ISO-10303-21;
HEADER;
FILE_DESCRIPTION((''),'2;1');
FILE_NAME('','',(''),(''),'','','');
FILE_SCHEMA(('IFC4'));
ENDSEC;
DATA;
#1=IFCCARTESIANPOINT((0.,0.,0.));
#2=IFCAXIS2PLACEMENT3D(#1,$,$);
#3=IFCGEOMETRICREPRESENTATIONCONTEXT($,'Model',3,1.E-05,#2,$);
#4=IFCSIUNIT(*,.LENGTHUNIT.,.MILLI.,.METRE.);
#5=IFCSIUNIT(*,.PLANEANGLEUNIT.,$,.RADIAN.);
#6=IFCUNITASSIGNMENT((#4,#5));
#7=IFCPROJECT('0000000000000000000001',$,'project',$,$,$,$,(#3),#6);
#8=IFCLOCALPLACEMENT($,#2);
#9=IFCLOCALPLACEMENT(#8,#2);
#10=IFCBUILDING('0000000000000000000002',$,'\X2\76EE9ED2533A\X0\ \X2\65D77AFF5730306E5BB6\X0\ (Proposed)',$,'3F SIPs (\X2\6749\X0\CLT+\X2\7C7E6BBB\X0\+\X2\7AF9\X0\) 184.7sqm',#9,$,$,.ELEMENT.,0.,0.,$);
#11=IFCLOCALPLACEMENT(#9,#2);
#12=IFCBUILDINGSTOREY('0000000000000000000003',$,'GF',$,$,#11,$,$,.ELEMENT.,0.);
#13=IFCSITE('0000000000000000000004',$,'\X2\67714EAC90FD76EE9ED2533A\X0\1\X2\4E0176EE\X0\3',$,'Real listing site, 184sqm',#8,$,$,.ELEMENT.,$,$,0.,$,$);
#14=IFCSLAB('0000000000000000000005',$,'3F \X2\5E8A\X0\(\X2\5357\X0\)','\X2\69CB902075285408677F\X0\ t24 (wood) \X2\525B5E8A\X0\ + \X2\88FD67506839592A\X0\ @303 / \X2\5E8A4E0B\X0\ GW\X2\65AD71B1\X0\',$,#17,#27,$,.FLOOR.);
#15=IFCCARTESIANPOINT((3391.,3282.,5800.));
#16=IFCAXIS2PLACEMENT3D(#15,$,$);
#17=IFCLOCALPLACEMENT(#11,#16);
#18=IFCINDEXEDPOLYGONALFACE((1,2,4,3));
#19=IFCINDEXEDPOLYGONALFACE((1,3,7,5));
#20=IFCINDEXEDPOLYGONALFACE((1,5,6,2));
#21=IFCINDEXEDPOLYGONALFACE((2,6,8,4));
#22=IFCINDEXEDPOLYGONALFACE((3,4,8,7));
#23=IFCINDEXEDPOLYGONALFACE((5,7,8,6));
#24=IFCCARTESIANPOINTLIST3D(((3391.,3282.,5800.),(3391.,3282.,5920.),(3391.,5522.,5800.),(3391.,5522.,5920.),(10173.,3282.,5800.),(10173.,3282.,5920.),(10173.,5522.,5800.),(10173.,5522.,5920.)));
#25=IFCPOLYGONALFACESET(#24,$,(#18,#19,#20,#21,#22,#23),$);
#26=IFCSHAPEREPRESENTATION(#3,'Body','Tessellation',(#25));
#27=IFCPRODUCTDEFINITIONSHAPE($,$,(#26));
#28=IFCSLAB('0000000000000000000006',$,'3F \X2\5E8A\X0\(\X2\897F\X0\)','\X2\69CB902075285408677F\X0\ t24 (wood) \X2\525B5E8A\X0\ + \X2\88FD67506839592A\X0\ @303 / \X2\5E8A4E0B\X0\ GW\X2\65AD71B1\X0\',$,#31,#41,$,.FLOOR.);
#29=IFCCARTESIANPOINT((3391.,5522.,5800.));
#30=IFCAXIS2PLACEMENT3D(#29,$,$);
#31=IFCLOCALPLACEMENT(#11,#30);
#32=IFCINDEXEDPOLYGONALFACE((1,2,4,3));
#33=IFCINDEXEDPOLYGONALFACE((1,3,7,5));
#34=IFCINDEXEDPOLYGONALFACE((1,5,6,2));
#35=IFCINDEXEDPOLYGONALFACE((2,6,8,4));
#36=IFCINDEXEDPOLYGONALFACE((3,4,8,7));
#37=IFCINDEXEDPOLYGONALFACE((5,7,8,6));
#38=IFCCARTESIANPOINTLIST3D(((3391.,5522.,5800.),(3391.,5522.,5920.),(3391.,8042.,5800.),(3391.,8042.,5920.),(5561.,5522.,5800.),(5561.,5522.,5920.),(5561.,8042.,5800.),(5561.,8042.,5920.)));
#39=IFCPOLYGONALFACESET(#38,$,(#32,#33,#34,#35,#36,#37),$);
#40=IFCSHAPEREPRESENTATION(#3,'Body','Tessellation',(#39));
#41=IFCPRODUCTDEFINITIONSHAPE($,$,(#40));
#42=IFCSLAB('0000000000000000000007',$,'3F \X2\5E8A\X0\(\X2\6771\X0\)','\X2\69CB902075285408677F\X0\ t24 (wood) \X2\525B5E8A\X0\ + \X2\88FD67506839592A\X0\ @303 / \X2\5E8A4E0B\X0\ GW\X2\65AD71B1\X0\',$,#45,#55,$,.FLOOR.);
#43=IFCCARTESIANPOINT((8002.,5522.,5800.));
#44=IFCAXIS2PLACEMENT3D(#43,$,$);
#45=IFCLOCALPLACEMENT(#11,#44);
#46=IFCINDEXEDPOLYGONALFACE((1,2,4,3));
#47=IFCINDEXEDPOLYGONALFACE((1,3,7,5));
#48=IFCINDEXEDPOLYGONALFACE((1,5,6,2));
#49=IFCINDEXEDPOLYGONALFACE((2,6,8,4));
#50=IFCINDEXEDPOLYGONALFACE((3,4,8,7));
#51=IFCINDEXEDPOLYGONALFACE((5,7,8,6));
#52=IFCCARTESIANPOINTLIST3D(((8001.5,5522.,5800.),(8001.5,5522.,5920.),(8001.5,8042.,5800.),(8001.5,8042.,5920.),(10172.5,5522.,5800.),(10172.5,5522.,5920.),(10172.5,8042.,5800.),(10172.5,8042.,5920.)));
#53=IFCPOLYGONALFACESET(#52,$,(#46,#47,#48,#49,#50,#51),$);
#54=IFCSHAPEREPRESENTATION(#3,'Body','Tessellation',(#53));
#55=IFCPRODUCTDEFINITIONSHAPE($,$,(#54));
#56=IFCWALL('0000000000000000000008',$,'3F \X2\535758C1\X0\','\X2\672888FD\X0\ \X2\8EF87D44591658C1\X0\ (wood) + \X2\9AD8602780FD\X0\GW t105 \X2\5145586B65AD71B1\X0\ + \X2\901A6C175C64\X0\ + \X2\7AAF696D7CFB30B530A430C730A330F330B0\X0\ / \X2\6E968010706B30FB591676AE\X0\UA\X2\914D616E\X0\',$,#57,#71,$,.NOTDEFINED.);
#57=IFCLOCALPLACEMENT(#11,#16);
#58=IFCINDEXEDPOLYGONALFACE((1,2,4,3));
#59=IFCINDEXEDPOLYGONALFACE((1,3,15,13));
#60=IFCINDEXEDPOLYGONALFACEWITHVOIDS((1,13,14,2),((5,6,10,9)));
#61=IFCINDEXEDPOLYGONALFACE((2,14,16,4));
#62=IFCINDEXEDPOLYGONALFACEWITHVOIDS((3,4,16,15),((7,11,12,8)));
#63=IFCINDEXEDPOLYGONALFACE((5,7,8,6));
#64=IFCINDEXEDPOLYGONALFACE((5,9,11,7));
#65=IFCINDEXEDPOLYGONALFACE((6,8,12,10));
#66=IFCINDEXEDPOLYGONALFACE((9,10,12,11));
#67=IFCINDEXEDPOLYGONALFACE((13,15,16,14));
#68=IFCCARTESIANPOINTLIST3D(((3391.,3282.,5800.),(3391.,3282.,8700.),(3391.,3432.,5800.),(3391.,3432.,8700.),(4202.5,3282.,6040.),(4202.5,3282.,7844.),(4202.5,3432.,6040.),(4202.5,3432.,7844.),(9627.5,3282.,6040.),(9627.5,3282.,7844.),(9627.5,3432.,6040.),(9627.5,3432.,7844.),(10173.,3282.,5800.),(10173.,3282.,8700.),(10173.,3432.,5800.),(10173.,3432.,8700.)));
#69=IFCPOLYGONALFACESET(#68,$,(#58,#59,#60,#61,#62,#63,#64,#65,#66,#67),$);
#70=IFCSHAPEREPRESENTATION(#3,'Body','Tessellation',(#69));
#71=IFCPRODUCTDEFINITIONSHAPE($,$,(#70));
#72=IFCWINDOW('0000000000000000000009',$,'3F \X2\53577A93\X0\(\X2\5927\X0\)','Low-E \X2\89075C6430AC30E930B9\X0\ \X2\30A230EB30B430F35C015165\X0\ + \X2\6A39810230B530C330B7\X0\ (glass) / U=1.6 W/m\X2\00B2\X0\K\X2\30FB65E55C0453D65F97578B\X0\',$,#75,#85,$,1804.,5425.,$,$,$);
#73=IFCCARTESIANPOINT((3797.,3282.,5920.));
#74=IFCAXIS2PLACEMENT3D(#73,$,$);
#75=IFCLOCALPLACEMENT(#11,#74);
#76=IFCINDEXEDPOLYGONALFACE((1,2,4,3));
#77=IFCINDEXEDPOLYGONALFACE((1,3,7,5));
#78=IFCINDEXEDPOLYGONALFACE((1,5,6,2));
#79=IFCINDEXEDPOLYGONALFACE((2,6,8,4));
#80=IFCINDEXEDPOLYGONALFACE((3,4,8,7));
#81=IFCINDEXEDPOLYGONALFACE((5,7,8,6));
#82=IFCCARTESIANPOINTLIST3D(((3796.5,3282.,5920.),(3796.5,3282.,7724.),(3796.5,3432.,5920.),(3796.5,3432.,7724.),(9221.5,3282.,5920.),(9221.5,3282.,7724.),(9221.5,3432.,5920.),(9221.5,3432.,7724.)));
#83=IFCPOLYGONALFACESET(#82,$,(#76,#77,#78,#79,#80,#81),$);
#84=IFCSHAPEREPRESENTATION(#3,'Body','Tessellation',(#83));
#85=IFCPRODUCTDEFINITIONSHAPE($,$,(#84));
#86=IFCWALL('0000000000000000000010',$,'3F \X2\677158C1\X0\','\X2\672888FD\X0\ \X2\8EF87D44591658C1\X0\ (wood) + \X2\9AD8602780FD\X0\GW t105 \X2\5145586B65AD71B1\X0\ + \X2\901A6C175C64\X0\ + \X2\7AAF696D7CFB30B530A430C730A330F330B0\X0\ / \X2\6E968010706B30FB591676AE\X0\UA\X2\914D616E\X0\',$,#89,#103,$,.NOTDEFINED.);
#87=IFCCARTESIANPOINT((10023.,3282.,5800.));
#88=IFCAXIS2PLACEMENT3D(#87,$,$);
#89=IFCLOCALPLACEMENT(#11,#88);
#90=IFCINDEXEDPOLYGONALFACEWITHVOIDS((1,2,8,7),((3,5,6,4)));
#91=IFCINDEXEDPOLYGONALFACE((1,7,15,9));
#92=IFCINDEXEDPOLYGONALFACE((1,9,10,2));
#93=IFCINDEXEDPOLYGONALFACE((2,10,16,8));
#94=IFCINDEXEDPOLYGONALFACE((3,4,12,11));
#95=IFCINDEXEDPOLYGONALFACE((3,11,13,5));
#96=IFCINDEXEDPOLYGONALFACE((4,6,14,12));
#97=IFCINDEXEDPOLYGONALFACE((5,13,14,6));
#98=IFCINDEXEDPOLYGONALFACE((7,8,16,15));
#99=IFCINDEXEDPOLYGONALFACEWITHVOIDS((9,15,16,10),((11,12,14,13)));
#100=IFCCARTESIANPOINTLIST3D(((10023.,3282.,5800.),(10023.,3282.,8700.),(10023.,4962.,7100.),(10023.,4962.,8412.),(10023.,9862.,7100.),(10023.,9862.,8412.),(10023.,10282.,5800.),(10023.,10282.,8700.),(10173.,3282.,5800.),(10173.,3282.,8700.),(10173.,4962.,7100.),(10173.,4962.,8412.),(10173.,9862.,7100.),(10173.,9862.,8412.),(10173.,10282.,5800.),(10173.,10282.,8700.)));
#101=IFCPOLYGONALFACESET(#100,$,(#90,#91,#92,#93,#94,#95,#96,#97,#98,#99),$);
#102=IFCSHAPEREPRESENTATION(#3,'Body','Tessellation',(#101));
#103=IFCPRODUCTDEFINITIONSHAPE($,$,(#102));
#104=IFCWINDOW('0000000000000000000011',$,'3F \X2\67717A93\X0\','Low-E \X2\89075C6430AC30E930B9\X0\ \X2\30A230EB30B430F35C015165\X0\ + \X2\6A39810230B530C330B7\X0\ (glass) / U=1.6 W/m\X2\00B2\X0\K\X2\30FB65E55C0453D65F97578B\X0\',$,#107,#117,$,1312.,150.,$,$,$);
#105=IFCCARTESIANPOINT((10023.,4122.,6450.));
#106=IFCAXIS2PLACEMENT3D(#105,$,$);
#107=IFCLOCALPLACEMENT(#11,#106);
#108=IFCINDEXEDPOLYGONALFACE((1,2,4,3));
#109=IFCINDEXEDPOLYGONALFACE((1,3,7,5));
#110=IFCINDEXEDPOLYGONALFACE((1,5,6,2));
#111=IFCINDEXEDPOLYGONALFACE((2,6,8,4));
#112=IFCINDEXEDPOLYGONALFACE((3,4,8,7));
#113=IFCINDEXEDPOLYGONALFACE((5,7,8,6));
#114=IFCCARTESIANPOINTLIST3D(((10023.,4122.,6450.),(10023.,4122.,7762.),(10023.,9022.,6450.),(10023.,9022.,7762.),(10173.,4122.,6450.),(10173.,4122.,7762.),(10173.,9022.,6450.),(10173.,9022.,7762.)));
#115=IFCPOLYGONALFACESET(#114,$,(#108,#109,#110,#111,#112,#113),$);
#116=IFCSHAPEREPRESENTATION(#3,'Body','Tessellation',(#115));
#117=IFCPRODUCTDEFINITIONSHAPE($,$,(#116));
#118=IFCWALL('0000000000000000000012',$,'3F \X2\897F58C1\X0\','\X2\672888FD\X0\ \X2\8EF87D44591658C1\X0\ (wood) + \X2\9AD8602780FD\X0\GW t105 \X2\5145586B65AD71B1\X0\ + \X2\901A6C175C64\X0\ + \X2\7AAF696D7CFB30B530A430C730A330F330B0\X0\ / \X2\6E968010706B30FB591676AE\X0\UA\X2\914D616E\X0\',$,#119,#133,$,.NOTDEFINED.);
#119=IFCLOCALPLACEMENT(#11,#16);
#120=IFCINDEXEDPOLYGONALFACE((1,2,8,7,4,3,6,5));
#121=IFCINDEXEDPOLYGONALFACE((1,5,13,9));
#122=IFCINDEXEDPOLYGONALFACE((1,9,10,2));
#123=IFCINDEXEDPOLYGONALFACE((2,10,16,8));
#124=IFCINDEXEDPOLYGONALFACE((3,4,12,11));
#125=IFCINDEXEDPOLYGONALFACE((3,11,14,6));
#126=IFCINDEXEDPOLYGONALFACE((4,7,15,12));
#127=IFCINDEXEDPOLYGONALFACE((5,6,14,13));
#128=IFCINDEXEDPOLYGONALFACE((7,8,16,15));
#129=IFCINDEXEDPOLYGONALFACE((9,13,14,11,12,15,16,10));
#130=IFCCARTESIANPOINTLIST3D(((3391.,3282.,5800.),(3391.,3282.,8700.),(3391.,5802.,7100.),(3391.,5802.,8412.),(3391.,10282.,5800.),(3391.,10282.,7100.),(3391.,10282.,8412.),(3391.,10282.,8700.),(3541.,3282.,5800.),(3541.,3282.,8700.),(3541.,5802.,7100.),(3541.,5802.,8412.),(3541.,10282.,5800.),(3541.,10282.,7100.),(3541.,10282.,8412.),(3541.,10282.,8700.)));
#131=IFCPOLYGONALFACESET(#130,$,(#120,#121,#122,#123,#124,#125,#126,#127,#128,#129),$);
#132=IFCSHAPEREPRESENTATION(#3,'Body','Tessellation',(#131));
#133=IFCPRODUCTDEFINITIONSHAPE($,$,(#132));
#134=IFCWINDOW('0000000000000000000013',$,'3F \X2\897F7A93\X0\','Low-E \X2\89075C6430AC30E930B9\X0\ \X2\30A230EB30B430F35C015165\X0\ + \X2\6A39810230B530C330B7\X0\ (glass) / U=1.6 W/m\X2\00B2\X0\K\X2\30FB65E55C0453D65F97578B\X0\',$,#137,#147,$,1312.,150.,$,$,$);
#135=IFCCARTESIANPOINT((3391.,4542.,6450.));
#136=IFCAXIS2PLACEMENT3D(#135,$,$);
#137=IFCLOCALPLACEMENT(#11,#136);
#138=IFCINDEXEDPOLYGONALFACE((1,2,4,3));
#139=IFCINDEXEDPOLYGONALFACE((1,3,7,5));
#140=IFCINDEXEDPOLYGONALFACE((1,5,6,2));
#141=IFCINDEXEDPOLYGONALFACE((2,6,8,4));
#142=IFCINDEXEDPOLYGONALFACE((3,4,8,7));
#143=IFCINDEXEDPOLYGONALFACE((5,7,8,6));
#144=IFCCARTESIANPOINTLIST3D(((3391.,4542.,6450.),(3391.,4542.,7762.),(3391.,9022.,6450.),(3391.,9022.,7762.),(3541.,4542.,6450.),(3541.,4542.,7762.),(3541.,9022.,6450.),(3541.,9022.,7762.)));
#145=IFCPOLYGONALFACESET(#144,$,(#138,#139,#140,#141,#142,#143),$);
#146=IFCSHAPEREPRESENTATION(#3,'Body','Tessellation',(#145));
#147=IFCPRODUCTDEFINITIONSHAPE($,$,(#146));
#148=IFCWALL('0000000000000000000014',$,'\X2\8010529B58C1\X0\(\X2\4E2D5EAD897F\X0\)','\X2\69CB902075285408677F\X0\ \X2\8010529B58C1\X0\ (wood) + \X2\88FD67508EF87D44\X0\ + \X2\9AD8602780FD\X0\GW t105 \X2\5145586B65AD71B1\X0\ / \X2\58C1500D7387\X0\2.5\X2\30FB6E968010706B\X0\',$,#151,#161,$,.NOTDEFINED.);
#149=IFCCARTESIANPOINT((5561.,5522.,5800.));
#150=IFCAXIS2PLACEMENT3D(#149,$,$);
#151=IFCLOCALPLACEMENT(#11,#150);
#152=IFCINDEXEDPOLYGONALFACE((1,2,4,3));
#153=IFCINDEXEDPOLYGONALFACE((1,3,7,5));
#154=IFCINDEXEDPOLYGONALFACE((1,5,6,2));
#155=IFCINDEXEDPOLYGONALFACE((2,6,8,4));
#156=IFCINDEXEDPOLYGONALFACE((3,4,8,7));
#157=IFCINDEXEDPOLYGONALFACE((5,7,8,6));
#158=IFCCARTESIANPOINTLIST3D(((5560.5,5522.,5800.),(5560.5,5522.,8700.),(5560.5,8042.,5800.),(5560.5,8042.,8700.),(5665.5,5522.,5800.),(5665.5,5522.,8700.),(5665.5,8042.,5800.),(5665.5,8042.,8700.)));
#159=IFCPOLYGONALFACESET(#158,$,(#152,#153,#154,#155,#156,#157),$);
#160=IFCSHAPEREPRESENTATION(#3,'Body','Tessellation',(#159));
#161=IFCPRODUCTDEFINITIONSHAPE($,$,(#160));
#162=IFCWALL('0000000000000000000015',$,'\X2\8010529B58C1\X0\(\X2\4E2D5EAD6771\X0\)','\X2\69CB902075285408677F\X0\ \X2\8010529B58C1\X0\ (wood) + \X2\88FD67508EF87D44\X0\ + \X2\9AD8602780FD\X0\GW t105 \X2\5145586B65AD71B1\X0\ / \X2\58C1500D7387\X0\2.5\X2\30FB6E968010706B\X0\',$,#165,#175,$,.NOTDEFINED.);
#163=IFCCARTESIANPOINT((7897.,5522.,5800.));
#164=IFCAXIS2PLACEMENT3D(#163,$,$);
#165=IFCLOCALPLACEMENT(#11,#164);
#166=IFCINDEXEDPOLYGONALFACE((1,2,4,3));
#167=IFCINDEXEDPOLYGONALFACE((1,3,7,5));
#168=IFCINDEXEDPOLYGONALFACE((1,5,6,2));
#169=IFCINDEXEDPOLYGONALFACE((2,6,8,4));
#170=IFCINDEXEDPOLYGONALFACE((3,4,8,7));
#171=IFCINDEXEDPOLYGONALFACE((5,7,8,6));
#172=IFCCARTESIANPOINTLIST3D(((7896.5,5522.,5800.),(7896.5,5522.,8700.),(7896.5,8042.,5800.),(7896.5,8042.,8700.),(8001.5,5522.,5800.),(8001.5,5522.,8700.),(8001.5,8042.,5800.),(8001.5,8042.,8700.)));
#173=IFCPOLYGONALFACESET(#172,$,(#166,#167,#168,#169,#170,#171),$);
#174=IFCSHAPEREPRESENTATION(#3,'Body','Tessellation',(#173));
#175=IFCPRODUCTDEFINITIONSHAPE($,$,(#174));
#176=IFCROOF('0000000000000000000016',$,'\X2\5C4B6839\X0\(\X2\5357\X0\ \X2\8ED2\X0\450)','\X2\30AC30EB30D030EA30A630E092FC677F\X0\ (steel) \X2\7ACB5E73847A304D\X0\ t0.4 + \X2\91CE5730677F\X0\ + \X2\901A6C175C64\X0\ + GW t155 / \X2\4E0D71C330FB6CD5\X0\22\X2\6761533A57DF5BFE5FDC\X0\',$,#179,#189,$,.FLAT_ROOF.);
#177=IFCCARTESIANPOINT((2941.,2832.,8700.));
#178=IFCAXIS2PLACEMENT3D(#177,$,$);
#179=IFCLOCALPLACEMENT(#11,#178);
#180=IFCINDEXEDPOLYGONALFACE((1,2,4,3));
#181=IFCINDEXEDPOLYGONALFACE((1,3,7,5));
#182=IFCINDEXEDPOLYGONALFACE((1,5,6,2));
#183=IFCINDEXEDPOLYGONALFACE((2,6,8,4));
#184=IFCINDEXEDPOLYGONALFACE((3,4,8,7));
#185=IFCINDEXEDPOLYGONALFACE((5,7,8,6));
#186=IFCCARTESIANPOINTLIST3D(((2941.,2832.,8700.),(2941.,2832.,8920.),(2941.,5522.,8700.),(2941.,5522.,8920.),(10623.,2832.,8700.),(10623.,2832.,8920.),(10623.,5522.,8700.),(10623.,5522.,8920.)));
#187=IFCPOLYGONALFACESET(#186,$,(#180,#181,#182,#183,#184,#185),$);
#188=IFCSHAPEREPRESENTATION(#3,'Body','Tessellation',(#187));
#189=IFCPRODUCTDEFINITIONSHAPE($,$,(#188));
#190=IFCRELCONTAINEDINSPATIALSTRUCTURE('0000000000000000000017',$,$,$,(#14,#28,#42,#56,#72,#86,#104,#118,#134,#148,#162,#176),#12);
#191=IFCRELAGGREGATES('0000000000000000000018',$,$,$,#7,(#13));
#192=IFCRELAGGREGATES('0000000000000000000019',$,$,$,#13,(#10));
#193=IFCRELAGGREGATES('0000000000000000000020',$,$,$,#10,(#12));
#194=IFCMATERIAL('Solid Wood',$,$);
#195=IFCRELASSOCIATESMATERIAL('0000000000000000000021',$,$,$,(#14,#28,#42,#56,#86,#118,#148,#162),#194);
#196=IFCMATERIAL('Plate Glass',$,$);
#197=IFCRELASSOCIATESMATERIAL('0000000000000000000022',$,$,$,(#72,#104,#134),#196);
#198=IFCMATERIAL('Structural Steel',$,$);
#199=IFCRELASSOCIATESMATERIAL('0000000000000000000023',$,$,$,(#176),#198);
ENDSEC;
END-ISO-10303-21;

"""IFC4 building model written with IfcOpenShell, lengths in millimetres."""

from ifc_helpers import new_model, si_unit, frame, frame_2d, origin, place, context, project, spatial, rectangle, extrude, material, element, fill, save


model = new_model("IFC4")

# Units and contexts
model_context = context("Model", 3, precision=1e-05, world=origin())
ifc_project = project(units=[si_unit("LENGTHUNIT", "METRE", prefix="MILLI"), si_unit("PLANEANGLEUNIT", "RADIAN")], contexts=[model_context])

# Site, building, storey
site_placement = place(None, origin())
site = spatial("IfcSite", under=ifc_project, at=site_placement, Name="東京都目黒区1丁目3", ObjectType="Real listing site, 184sqm", CompositionType="ELEMENT", RefElevation=0.0)
building_placement = place(site_placement, origin())
building = spatial("IfcBuilding", under=site, at=building_placement, Name="目黒区 旗竿地の家 (Proposed)", ObjectType="3F SIPs (杉CLT+籾殻+竹) 184.7sqm", CompositionType="ELEMENT", ElevationOfRefHeight=0.0, ElevationOfTerrain=0.0)
storey_placement = place(building_placement, origin())
storey = spatial("IfcBuildingStorey", under=building, at=storey_placement, Name="GF", CompositionType="ELEMENT", Elevation=0.0)

# Slabs
ifc_material_1 = material(Name="Solid Wood")
slab_1_placement = place(storey_placement, frame((3391.0, 3282.0, 5800.0)))
element("IfcSlab", 1, at=slab_1_placement, inside=storey, material=ifc_material_1, Name="3F 床(南)", Description="構造用合板 t24 (wood) 剛床 + 製材根太 @303 / 床下 GW断熱", PredefinedType="FLOOR", context=model_context, shape_type="SweptSolid", body=[
    extrude(rectangle(XDim=6782.0, YDim=2240.0, at=frame_2d((3391.0, 1120.0))), frame((3391.0, 3282.0, 5800.0)), (0.0, 0.0, 1.0), 120.0),
])
slab_2_placement = place(storey_placement, frame((3391.0, 5522.0, 5800.0)))
element("IfcSlab", 2, at=slab_2_placement, inside=storey, material=ifc_material_1, Name="3F 床(西)", Description="構造用合板 t24 (wood) 剛床 + 製材根太 @303 / 床下 GW断熱", PredefinedType="FLOOR", context=model_context, shape_type="SweptSolid", body=[
    extrude(rectangle(XDim=2170.0, YDim=2520.0, at=frame_2d((1085.0, 1260.0))), frame((3391.0, 5522.0, 5800.0)), (0.0, 0.0, 1.0), 120.0),
])
slab_3_placement = place(storey_placement, frame((8002.0, 5522.0, 5800.0)))
element("IfcSlab", 3, at=slab_3_placement, inside=storey, material=ifc_material_1, Name="3F 床(東)", Description="構造用合板 t24 (wood) 剛床 + 製材根太 @303 / 床下 GW断熱", PredefinedType="FLOOR", context=model_context, shape_type="SweptSolid", body=[
    extrude(rectangle(XDim=2171.0, YDim=2520.0, at=frame_2d((1085.0, 1260.0))), frame((8002.0, 5522.0, 5800.0)), (0.0, 0.0, 1.0), 120.0),
])

# Walls, openings, windows
wall_1_placement = place(storey_placement, frame((3391.0, 3282.0, 5800.0)))
wall_1 = element("IfcWall", 4, at=wall_1_placement, inside=storey, material=ifc_material_1, Name="3F 南壁", Description="木製 軸組外壁 (wood) + 高性能GW t105 充填断熱 + 通気層 + 窯業系サイディング / 準耐火・外皮UA配慮", PredefinedType="NOTDEFINED", context=model_context, shape_type="SweptSolid", body=[
    extrude(rectangle(XDim=6782.0, YDim=150.0, at=frame_2d((3391.0, 75.0))), frame((3391.0, 3282.0, 5800.0)), (0.0, 0.0, 1.0), 2900.0),
])
opening_1_placement = place(storey_placement, frame((3797.0, 3282.0, 5920.0)))
opening_1 = element("IfcOpeningElement", 5, at=opening_1_placement, cuts=wall_1, PredefinedType="NOTDEFINED", context=model_context, shape_type="SweptSolid", body=[
    extrude(rectangle(XDim=5425.0, YDim=150.0, at=frame_2d((2712.0, 75.0))), frame((3797.0, 3282.0, 5920.0)), (0.0, 0.0, 1.0), 1804.0),
])
ifc_material_2 = material(Name="Plate Glass")
window_1_placement = place(storey_placement, frame((3797.0, 3282.0, 5920.0)))
window_1 = element("IfcWindow", 6, at=window_1_placement, inside=storey, material=ifc_material_2, Name="3F 南窓(大)", Description="Low-E 複層ガラス アルゴン封入 + 樹脂サッシ (glass) / U=1.6 W/m²K・日射取得型", OverallHeight=1804.0, OverallWidth=5425.0, context=model_context, shape_type="SweptSolid", body=[
    extrude(rectangle(XDim=5425.0, YDim=150.0, at=frame_2d((2712.0, 75.0))), frame((3797.0, 3282.0, 5920.0)), (0.0, 0.0, 1.0), 1804.0),
])
fill(opening_1, window_1)
wall_2_placement = place(storey_placement, frame((10023.0, 3282.0, 5800.0)))
wall_2 = element("IfcWall", 7, at=wall_2_placement, inside=storey, material=ifc_material_1, Name="3F 東壁", Description="木製 軸組外壁 (wood) + 高性能GW t105 充填断熱 + 通気層 + 窯業系サイディング / 準耐火・外皮UA配慮", PredefinedType="NOTDEFINED", context=model_context, shape_type="SweptSolid", body=[
    extrude(rectangle(XDim=150.0, YDim=7000.0, at=frame_2d((75.0, 3500.0))), frame((10023.0, 3282.0, 5800.0)), (0.0, 0.0, 1.0), 2900.0),
])
opening_2_placement = place(storey_placement, frame((10023.0, 4122.0, 6450.0)))
opening_2 = element("IfcOpeningElement", 8, at=opening_2_placement, cuts=wall_2, PredefinedType="NOTDEFINED", context=model_context, shape_type="SweptSolid", body=[
    extrude(rectangle(XDim=150.0, YDim=4900.0, at=frame_2d((75.0, 2450.0))), frame((10023.0, 4122.0, 6450.0)), (0.0, 0.0, 1.0), 1312.0),
])
window_2_placement = place(storey_placement, frame((10023.0, 4122.0, 6450.0)))
window_2 = element("IfcWindow", 9, at=window_2_placement, inside=storey, material=ifc_material_2, Name="3F 東窓", Description="Low-E 複層ガラス アルゴン封入 + 樹脂サッシ (glass) / U=1.6 W/m²K・日射取得型", OverallHeight=1312.0, OverallWidth=150.0, context=model_context, shape_type="SweptSolid", body=[
    extrude(rectangle(XDim=150.0, YDim=4900.0, at=frame_2d((75.0, 2450.0))), frame((10023.0, 4122.0, 6450.0)), (0.0, 0.0, 1.0), 1312.0),
])
fill(opening_2, window_2)
wall_3_placement = place(storey_placement, frame((3391.0, 3282.0, 5800.0)))
wall_3 = element("IfcWall", 10, at=wall_3_placement, inside=storey, material=ifc_material_1, Name="3F 西壁", Description="木製 軸組外壁 (wood) + 高性能GW t105 充填断熱 + 通気層 + 窯業系サイディング / 準耐火・外皮UA配慮", PredefinedType="NOTDEFINED", context=model_context, shape_type="SweptSolid", body=[
    extrude(rectangle(XDim=150.0, YDim=7000.0, at=frame_2d((75.0, 3500.0))), frame((3391.0, 3282.0, 5800.0)), (0.0, 0.0, 1.0), 2900.0),
])
opening_3_placement = place(storey_placement, frame((3391.0, 4542.0, 6450.0)))
opening_3 = element("IfcOpeningElement", 11, at=opening_3_placement, cuts=wall_3, PredefinedType="NOTDEFINED", context=model_context, shape_type="SweptSolid", body=[
    extrude(rectangle(XDim=150.0, YDim=4480.0, at=frame_2d((75.0, 2240.0))), frame((3391.0, 4542.0, 6450.0)), (0.0, 0.0, 1.0), 1312.0),
])
window_3_placement = place(storey_placement, frame((3391.0, 4542.0, 6450.0)))
window_3 = element("IfcWindow", 12, at=window_3_placement, inside=storey, material=ifc_material_2, Name="3F 西窓", Description="Low-E 複層ガラス アルゴン封入 + 樹脂サッシ (glass) / U=1.6 W/m²K・日射取得型", OverallHeight=1312.0, OverallWidth=150.0, context=model_context, shape_type="SweptSolid", body=[
    extrude(rectangle(XDim=150.0, YDim=4480.0, at=frame_2d((75.0, 2240.0))), frame((3391.0, 4542.0, 6450.0)), (0.0, 0.0, 1.0), 1312.0),
])
fill(opening_3, window_3)

# Walls
wall_4_placement = place(storey_placement, frame((5561.0, 5522.0, 5800.0)))
element("IfcWall", 13, at=wall_4_placement, inside=storey, material=ifc_material_1, Name="耐力壁(中庭西)", Description="構造用合板 耐力壁 (wood) + 製材軸組 + 高性能GW t105 充填断熱 / 壁倍率2.5・準耐火", PredefinedType="NOTDEFINED", context=model_context, shape_type="SweptSolid", body=[
    extrude(rectangle(XDim=105.0, YDim=2520.0, at=frame_2d((52.0, 1260.0))), frame((5561.0, 5522.0, 5800.0)), (0.0, 0.0, 1.0), 2900.0),
])
wall_5_placement = place(storey_placement, frame((7897.0, 5522.0, 5800.0)))
element("IfcWall", 14, at=wall_5_placement, inside=storey, material=ifc_material_1, Name="耐力壁(中庭東)", Description="構造用合板 耐力壁 (wood) + 製材軸組 + 高性能GW t105 充填断熱 / 壁倍率2.5・準耐火", PredefinedType="NOTDEFINED", context=model_context, shape_type="SweptSolid", body=[
    extrude(rectangle(XDim=105.0, YDim=2520.0, at=frame_2d((52.0, 1260.0))), frame((7897.0, 5522.0, 5800.0)), (0.0, 0.0, 1.0), 2900.0),
])

# Roof
ifc_material_3 = material(Name="Structural Steel")
roof_1_placement = place(storey_placement, frame((2941.0, 2832.0, 8700.0)))
element("IfcRoof", 15, at=roof_1_placement, inside=storey, material=ifc_material_3, Name="屋根(南 軒450)", Description="ガルバリウム鋼板 (steel) 立平葺き t0.4 + 野地板 + 通気層 + GW t155 / 不燃・法22条区域対応", PredefinedType="FLAT_ROOF", context=model_context, shape_type="SweptSolid", body=[
    extrude(rectangle(XDim=7682.0, YDim=2690.0, at=frame_2d((3841.0, 1345.0))), frame((2941.0, 2832.0, 8700.0)), (0.0, 0.0, 1.0), 220.0),
])

save(model, "model.ifc")
